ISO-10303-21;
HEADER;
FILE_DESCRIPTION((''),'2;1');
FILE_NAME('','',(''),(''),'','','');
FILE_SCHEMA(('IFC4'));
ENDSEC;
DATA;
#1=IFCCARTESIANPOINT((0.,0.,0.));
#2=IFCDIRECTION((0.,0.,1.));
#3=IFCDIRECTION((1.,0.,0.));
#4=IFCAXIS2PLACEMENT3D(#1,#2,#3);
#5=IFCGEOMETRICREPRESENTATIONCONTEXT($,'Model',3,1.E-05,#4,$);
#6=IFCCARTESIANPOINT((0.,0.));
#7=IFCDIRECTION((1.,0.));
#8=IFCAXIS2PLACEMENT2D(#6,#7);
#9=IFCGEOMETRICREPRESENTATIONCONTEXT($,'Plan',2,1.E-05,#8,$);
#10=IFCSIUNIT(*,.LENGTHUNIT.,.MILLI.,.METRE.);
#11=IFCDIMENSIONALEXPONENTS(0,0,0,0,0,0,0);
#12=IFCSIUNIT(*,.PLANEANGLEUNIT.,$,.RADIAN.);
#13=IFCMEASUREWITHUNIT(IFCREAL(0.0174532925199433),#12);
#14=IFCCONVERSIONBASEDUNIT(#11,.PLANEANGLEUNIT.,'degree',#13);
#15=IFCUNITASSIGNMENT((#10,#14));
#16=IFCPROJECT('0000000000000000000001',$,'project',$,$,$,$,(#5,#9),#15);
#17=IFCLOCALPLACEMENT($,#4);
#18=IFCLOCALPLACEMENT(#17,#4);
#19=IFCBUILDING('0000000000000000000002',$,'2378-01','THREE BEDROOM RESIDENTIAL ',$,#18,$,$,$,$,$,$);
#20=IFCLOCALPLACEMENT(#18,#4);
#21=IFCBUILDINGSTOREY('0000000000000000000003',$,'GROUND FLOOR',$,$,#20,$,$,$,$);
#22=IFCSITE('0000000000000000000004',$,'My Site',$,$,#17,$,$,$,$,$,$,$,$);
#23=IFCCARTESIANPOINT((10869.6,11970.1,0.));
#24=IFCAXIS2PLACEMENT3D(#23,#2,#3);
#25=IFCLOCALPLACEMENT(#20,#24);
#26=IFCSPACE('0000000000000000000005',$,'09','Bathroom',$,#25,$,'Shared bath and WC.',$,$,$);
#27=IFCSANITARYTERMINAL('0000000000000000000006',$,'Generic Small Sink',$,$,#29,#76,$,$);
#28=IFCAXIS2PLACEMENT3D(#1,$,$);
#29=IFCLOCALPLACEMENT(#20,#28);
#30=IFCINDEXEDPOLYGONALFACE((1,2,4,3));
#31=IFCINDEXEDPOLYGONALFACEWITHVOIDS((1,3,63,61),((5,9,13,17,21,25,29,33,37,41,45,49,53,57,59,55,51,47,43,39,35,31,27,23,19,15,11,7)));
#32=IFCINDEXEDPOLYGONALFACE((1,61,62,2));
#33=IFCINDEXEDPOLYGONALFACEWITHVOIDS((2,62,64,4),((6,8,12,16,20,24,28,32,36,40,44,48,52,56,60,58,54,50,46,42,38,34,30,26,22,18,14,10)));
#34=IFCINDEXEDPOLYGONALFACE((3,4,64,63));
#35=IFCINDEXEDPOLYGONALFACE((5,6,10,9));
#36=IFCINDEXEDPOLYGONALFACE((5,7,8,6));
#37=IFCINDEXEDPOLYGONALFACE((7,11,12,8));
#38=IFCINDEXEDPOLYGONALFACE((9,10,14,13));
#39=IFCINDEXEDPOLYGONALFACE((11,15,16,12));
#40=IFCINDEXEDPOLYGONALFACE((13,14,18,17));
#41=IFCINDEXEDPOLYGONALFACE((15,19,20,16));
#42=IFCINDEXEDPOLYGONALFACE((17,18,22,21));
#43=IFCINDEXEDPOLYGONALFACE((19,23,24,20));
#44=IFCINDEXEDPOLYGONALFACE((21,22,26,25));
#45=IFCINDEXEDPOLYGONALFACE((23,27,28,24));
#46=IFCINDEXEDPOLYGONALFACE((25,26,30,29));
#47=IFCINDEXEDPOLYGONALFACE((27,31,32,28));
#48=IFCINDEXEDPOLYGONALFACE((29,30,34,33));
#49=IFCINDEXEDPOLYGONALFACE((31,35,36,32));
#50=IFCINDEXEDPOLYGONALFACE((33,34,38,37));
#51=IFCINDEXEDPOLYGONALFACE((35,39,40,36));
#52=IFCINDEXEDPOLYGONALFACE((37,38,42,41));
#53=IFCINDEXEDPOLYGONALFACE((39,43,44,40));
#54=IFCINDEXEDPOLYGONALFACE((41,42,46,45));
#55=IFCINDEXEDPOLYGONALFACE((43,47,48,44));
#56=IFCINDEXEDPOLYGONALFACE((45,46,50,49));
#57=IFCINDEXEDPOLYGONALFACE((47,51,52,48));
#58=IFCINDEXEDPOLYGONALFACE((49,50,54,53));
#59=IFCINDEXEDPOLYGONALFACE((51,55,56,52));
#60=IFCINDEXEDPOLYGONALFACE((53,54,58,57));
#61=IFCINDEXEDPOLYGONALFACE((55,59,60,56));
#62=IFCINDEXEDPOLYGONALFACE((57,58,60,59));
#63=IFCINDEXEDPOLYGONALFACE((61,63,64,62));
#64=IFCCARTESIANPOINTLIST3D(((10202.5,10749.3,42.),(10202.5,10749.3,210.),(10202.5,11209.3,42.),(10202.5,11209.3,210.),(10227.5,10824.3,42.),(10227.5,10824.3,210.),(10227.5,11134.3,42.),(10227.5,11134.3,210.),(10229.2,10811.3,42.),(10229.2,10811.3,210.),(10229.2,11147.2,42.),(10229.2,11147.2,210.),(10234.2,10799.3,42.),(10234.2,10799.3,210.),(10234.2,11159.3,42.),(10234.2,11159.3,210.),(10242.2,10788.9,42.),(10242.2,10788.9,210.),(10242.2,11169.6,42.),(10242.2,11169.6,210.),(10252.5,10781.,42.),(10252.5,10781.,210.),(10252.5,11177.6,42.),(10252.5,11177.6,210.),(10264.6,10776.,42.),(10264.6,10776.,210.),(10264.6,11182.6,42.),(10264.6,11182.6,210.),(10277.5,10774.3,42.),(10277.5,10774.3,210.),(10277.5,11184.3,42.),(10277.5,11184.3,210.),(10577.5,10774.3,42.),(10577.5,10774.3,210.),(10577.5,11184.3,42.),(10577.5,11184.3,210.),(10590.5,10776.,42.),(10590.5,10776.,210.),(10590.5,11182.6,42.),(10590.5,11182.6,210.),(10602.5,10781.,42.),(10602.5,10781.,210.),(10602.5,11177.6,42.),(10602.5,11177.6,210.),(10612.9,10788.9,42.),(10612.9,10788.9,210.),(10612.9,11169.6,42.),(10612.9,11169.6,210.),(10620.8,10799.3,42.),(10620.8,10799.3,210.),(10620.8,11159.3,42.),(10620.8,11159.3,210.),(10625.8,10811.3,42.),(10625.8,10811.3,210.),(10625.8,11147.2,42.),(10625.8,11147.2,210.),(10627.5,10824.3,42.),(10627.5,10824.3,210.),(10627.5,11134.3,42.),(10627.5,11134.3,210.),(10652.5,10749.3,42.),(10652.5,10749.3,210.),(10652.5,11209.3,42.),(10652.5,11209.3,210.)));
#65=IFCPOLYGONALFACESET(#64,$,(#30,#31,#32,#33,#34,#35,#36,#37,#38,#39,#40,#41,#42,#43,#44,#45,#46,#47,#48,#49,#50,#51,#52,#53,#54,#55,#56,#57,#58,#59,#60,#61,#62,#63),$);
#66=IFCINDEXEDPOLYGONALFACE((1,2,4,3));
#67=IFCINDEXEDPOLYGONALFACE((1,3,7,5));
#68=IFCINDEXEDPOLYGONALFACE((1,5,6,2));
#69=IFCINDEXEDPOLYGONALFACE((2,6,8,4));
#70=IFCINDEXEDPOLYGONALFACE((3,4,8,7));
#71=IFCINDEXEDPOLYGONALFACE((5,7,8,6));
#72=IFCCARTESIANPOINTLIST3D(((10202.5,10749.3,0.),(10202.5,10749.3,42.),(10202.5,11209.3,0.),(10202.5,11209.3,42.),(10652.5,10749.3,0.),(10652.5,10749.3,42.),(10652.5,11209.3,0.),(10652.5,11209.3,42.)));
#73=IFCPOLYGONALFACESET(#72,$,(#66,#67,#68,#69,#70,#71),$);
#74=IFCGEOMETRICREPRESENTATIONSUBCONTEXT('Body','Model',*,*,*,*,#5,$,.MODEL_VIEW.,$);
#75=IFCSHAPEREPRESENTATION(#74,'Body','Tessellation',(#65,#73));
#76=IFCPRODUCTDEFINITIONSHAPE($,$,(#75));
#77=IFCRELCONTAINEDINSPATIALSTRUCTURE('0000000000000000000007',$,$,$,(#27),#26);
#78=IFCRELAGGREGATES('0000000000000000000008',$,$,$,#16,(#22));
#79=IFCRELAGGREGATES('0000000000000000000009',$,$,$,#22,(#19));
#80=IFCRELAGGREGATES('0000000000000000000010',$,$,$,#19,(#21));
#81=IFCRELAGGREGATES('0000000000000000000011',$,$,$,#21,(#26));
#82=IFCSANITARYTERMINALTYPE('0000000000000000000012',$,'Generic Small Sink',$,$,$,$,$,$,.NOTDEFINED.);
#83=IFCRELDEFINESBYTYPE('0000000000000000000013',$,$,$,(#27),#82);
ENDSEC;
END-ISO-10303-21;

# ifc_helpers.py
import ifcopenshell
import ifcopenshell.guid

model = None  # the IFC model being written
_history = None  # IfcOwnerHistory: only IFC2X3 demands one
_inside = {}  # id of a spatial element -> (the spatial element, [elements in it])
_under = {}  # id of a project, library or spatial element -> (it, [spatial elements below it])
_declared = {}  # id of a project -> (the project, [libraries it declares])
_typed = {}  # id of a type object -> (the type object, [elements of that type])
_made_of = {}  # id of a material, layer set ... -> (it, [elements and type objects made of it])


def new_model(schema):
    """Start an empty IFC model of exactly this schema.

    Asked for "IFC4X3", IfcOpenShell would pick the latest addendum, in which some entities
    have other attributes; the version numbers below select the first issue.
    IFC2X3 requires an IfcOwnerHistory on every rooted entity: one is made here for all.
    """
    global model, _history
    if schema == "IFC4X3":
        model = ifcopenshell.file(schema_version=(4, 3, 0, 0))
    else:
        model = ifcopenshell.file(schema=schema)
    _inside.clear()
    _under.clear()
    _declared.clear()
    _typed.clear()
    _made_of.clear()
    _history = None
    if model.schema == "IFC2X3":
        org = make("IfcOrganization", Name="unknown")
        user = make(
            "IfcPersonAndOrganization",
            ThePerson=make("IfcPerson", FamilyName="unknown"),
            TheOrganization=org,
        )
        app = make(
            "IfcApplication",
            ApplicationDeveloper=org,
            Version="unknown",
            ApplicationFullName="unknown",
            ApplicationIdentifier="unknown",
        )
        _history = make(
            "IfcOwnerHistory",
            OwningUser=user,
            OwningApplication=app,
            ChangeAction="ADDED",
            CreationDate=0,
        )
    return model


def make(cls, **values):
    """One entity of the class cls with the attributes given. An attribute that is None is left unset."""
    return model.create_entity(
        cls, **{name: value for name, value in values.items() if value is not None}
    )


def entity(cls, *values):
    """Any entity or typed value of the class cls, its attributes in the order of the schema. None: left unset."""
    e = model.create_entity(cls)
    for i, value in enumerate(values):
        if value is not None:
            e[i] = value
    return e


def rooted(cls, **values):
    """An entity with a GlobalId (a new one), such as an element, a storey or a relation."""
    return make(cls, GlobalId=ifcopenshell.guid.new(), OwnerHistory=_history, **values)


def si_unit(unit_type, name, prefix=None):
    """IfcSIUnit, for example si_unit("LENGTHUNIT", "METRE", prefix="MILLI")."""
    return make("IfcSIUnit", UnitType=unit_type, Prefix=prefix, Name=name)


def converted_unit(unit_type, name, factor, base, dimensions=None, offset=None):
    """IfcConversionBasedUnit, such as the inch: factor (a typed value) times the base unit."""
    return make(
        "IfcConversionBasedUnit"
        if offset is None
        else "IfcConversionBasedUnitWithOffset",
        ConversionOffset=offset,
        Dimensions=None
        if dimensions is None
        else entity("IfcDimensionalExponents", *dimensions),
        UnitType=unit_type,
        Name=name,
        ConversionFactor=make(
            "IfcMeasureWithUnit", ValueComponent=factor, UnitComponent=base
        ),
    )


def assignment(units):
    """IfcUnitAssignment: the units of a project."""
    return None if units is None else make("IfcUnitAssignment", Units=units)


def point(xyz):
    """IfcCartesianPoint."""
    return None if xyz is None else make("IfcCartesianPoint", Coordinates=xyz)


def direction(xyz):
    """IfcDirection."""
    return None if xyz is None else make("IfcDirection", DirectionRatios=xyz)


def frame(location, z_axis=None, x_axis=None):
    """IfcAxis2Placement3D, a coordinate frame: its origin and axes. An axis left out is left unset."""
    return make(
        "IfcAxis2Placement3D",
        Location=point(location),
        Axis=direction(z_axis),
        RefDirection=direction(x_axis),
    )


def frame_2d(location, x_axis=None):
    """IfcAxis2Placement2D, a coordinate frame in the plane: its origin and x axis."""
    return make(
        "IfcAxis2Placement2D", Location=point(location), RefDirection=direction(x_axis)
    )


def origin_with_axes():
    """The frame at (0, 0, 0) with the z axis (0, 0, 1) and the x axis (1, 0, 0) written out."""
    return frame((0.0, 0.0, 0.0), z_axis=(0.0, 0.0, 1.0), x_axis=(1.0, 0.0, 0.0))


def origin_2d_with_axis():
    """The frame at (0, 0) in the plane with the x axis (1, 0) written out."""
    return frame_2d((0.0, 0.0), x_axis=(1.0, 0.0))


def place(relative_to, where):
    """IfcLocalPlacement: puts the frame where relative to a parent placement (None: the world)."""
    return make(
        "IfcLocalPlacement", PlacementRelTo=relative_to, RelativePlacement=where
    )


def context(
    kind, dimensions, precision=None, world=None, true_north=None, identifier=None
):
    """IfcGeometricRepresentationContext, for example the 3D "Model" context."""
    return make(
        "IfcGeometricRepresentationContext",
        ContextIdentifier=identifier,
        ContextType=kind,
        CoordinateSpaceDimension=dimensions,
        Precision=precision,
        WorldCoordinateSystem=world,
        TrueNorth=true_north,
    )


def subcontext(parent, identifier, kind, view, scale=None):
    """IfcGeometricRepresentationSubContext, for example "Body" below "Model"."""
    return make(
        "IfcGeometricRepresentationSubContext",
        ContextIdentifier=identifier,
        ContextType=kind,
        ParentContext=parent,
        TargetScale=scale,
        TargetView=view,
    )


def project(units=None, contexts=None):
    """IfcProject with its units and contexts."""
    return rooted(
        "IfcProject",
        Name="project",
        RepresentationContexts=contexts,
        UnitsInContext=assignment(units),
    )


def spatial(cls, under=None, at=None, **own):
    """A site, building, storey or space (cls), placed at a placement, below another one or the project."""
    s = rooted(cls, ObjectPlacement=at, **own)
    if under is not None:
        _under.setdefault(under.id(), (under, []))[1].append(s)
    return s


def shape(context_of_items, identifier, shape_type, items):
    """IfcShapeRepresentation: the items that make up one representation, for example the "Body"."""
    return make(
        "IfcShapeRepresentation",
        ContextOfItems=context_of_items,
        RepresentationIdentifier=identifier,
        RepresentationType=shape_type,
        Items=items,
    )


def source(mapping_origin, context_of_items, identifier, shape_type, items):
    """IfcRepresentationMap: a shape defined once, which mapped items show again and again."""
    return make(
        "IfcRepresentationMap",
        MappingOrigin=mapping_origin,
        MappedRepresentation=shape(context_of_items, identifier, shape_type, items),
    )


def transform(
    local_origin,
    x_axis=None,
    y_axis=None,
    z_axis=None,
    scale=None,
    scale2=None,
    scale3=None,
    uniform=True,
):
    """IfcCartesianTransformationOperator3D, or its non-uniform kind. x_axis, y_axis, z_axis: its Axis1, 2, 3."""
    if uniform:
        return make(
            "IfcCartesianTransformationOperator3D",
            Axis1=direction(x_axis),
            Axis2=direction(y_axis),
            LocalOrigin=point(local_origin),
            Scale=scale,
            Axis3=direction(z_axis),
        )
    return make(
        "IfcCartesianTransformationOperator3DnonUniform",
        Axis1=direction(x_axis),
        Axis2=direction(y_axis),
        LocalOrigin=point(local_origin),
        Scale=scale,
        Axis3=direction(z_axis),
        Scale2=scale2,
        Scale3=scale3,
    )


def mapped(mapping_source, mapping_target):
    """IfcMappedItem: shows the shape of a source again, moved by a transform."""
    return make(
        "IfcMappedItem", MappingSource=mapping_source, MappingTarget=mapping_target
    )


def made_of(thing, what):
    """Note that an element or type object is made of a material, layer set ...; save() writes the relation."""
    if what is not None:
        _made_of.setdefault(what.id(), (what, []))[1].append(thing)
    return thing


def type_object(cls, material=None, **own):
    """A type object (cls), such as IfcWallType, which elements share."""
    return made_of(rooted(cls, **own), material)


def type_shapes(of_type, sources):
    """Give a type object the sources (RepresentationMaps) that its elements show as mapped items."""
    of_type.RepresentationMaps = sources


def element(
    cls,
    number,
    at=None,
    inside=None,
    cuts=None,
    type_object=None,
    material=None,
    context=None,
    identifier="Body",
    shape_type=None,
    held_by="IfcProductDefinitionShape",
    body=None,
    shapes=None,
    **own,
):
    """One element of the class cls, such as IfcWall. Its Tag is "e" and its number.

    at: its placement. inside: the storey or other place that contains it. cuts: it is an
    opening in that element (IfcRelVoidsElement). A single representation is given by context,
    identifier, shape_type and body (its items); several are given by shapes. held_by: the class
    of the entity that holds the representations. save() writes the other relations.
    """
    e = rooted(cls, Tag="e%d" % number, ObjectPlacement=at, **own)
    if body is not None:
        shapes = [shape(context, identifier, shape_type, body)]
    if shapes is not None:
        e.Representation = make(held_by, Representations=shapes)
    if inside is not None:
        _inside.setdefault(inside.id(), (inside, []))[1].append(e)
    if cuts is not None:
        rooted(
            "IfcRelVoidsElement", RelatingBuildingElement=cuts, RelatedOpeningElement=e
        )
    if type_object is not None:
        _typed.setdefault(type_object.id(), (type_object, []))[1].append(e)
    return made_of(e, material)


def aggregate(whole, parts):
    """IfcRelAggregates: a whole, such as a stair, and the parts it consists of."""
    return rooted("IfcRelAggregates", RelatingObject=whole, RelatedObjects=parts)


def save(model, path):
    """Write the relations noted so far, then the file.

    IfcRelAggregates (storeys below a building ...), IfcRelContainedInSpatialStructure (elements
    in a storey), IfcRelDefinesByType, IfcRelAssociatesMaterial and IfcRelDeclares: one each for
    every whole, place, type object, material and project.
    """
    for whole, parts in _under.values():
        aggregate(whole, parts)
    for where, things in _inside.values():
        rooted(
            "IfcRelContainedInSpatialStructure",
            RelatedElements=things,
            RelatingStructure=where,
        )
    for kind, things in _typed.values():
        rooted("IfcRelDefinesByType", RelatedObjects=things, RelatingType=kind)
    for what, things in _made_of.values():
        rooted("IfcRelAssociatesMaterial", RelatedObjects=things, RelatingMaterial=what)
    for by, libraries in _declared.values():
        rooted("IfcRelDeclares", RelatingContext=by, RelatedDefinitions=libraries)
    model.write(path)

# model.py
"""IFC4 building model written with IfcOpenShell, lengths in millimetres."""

from ifc_helpers import new_model, entity, si_unit, converted_unit, frame, origin_with_axes, origin_2d_with_axis, place, context, subcontext, project, spatial, shape, source, transform, mapped, type_object, type_shapes, element, save


model = new_model("IFC4")

# Units and contexts
model_context = context("Model", 3, precision=1e-05, world=origin_with_axes())
plan_context = context("Plan", 2, precision=1e-05, world=origin_2d_with_axis())
body_context_1 = subcontext(model_context, "Body", "Model", "MODEL_VIEW")
body_context_2 = subcontext(plan_context, "Body", "Plan", "PLAN_VIEW")
ifc_project = project(units=[si_unit("LENGTHUNIT", "METRE", prefix="MILLI"), converted_unit("PLANEANGLEUNIT", "degree", entity("IfcReal", 0.0174532925199433), si_unit("PLANEANGLEUNIT", "RADIAN"), dimensions=[0, 0, 0, 0, 0, 0, 0])], contexts=[model_context, plan_context])

# Site, building, storey
site_placement = place(None, origin_with_axes())
site = spatial("IfcSite", under=ifc_project, at=site_placement, Name="My Site")
building_placement = place(site_placement, origin_with_axes())
building = spatial("IfcBuilding", under=site, at=building_placement, Name="2378-01", Description="THREE BEDROOM RESIDENTIAL ")
storey_placement = place(building_placement, origin_with_axes())
storey = spatial("IfcBuildingStorey", under=building, at=storey_placement, Name="GROUND FLOOR")

# Shared definitions
space_placement = place(storey_placement, frame((10869.6, 11970.1, 0.0), z_axis=(0.0, 0.0, 1.0), x_axis=(1.0, 0.0, 0.0)))
space = spatial("IfcSpace", under=storey, at=space_placement, Name="09", Description="Bathroom", LongName="Shared bath and WC.")

# Sanitary terminal
sanitary_terminal_type_1 = type_object("IfcSanitaryTerminalType", Name="Generic Small Sink", PredefinedType="NOTDEFINED")
shared_indexed_poly_curve = entity("IfcIndexedPolyCurve", entity("IfcCartesianPointList2D", [[0.0, 0.0], [450.0, 0.0], [450.0, 460.0], [0.0, 460.0]]), [entity("IfcLineIndex", [1, 2, 3, 4, 1])])
shared_shape_1 = source(origin_with_axes(), body_context_1, "Body", "SweptSolid", [
    entity("IfcExtrudedAreaSolid", entity("IfcArbitraryProfileDefWithVoids", "AREA", None, shared_indexed_poly_curve, [entity("IfcIndexedPolyCurve", entity("IfcCartesianPointList2D", [[25.0, 75.0], [39.6, 39.6], [75.0, 25.0], [375.0, 25.0], [410.4, 39.6], [425.0, 75.0], [425.0, 385.0], [410.4, 420.4], [375.0, 435.0], [75.0, 435.0], [39.6, 420.4], [25.0, 385.0]]), [entity("IfcLineIndex", [12, 1]), entity("IfcArcIndex", [1, 2, 3]), entity("IfcLineIndex", [3, 4]), entity("IfcArcIndex", [4, 5, 6]), entity("IfcLineIndex", [6, 7]), entity("IfcArcIndex", [7, 8, 9]), entity("IfcLineIndex", [9, 10]), entity("IfcArcIndex", [10, 11, 12]), entity("IfcLineIndex", [12, 1])])]), entity("IfcAxis2Placement3D", entity("IfcCartesianPoint", [-225.0, -460.0, 42.0]), entity("IfcDirection", [0.0, 0.0, 1.0]), entity("IfcDirection", [1.0, 0.0, 0.0])), entity("IfcDirection", [0.0, 0.0, 1.0]), 168.0),
    entity("IfcExtrudedAreaSolid", entity("IfcArbitraryClosedProfileDef", "AREA", None, shared_indexed_poly_curve), entity("IfcAxis2Placement3D", entity("IfcCartesianPoint", [-225.0, -460.0, 0.0]), entity("IfcDirection", [0.0, 0.0, 1.0]), entity("IfcDirection", [1.0, 0.0, 0.0])), entity("IfcDirection", [0.0, 0.0, 1.0]), 42.0),
])
shared_shape_2 = source(origin_with_axes(), body_context_2, "Body", "Curve2D", [
    entity("IfcIndexedPolyCurve", entity("IfcCartesianPointList2D", [[-225.0, -460.0], [225.0, -460.0], [225.0, 0.0], [-225.0, 0.0]]), [entity("IfcLineIndex", [1, 2, 3, 4, 1])]),
    entity("IfcIndexedPolyCurve", entity("IfcCartesianPointList2D", [[-200.0, -385.0], [-185.4, -420.4], [-150.0, -435.0], [150.0, -435.0], [185.4, -420.4], [200.0, -385.0], [200.0, -75.0], [185.4, -39.6], [150.0, -25.0], [-150.0, -25.0], [-185.4, -39.6], [-200.0, -75.0]]), [entity("IfcLineIndex", [12, 1]), entity("IfcArcIndex", [1, 2, 3]), entity("IfcLineIndex", [3, 4]), entity("IfcArcIndex", [4, 5, 6]), entity("IfcLineIndex", [6, 7]), entity("IfcArcIndex", [7, 8, 9]), entity("IfcLineIndex", [9, 10]), entity("IfcArcIndex", [10, 11, 12]), entity("IfcLineIndex", [12, 1])]),
    entity("IfcCircle", entity("IfcAxis2Placement2D", entity("IfcCartesianPoint", [0.0, -125.0])), 25.0),
    entity("IfcIndexedPolyCurve", entity("IfcCartesianPointList2D", [[0.0, -12.5], [0.0, -132.5]])),
])
type_shapes(sanitary_terminal_type_1, [shared_shape_1, shared_shape_2])
sanitary_terminal_1_placement = place(space_placement, frame((-442.1, -1220.8, 0.0), z_axis=(0.0, 0.0, 1.0), x_axis=(-1.0, 0.0, 0.0)))
element("IfcSanitaryTerminal", 1, at=sanitary_terminal_1_placement, inside=space, type_object=sanitary_terminal_type_1, Name="Generic Small Sink", shapes=[
    shape(body_context_1, "Body", "MappedRepresentation", [mapped(shared_shape_1, transform((0.0, 0.0, 0.0), x_axis=(1.0, 0.0, 0.0), y_axis=(0.0, 1.0, 0.0), z_axis=(0.0, 0.0, 1.0), scale=1.0))]),
    shape(body_context_2, "Body", "MappedRepresentation", [mapped(shared_shape_2, transform((0.0, 0.0, 0.0), x_axis=(1.0, 0.0, 0.0), y_axis=(0.0, 1.0, 0.0), z_axis=(0.0, 0.0, 1.0), scale=1.0))]),
])

save(model, "model.ifc")
